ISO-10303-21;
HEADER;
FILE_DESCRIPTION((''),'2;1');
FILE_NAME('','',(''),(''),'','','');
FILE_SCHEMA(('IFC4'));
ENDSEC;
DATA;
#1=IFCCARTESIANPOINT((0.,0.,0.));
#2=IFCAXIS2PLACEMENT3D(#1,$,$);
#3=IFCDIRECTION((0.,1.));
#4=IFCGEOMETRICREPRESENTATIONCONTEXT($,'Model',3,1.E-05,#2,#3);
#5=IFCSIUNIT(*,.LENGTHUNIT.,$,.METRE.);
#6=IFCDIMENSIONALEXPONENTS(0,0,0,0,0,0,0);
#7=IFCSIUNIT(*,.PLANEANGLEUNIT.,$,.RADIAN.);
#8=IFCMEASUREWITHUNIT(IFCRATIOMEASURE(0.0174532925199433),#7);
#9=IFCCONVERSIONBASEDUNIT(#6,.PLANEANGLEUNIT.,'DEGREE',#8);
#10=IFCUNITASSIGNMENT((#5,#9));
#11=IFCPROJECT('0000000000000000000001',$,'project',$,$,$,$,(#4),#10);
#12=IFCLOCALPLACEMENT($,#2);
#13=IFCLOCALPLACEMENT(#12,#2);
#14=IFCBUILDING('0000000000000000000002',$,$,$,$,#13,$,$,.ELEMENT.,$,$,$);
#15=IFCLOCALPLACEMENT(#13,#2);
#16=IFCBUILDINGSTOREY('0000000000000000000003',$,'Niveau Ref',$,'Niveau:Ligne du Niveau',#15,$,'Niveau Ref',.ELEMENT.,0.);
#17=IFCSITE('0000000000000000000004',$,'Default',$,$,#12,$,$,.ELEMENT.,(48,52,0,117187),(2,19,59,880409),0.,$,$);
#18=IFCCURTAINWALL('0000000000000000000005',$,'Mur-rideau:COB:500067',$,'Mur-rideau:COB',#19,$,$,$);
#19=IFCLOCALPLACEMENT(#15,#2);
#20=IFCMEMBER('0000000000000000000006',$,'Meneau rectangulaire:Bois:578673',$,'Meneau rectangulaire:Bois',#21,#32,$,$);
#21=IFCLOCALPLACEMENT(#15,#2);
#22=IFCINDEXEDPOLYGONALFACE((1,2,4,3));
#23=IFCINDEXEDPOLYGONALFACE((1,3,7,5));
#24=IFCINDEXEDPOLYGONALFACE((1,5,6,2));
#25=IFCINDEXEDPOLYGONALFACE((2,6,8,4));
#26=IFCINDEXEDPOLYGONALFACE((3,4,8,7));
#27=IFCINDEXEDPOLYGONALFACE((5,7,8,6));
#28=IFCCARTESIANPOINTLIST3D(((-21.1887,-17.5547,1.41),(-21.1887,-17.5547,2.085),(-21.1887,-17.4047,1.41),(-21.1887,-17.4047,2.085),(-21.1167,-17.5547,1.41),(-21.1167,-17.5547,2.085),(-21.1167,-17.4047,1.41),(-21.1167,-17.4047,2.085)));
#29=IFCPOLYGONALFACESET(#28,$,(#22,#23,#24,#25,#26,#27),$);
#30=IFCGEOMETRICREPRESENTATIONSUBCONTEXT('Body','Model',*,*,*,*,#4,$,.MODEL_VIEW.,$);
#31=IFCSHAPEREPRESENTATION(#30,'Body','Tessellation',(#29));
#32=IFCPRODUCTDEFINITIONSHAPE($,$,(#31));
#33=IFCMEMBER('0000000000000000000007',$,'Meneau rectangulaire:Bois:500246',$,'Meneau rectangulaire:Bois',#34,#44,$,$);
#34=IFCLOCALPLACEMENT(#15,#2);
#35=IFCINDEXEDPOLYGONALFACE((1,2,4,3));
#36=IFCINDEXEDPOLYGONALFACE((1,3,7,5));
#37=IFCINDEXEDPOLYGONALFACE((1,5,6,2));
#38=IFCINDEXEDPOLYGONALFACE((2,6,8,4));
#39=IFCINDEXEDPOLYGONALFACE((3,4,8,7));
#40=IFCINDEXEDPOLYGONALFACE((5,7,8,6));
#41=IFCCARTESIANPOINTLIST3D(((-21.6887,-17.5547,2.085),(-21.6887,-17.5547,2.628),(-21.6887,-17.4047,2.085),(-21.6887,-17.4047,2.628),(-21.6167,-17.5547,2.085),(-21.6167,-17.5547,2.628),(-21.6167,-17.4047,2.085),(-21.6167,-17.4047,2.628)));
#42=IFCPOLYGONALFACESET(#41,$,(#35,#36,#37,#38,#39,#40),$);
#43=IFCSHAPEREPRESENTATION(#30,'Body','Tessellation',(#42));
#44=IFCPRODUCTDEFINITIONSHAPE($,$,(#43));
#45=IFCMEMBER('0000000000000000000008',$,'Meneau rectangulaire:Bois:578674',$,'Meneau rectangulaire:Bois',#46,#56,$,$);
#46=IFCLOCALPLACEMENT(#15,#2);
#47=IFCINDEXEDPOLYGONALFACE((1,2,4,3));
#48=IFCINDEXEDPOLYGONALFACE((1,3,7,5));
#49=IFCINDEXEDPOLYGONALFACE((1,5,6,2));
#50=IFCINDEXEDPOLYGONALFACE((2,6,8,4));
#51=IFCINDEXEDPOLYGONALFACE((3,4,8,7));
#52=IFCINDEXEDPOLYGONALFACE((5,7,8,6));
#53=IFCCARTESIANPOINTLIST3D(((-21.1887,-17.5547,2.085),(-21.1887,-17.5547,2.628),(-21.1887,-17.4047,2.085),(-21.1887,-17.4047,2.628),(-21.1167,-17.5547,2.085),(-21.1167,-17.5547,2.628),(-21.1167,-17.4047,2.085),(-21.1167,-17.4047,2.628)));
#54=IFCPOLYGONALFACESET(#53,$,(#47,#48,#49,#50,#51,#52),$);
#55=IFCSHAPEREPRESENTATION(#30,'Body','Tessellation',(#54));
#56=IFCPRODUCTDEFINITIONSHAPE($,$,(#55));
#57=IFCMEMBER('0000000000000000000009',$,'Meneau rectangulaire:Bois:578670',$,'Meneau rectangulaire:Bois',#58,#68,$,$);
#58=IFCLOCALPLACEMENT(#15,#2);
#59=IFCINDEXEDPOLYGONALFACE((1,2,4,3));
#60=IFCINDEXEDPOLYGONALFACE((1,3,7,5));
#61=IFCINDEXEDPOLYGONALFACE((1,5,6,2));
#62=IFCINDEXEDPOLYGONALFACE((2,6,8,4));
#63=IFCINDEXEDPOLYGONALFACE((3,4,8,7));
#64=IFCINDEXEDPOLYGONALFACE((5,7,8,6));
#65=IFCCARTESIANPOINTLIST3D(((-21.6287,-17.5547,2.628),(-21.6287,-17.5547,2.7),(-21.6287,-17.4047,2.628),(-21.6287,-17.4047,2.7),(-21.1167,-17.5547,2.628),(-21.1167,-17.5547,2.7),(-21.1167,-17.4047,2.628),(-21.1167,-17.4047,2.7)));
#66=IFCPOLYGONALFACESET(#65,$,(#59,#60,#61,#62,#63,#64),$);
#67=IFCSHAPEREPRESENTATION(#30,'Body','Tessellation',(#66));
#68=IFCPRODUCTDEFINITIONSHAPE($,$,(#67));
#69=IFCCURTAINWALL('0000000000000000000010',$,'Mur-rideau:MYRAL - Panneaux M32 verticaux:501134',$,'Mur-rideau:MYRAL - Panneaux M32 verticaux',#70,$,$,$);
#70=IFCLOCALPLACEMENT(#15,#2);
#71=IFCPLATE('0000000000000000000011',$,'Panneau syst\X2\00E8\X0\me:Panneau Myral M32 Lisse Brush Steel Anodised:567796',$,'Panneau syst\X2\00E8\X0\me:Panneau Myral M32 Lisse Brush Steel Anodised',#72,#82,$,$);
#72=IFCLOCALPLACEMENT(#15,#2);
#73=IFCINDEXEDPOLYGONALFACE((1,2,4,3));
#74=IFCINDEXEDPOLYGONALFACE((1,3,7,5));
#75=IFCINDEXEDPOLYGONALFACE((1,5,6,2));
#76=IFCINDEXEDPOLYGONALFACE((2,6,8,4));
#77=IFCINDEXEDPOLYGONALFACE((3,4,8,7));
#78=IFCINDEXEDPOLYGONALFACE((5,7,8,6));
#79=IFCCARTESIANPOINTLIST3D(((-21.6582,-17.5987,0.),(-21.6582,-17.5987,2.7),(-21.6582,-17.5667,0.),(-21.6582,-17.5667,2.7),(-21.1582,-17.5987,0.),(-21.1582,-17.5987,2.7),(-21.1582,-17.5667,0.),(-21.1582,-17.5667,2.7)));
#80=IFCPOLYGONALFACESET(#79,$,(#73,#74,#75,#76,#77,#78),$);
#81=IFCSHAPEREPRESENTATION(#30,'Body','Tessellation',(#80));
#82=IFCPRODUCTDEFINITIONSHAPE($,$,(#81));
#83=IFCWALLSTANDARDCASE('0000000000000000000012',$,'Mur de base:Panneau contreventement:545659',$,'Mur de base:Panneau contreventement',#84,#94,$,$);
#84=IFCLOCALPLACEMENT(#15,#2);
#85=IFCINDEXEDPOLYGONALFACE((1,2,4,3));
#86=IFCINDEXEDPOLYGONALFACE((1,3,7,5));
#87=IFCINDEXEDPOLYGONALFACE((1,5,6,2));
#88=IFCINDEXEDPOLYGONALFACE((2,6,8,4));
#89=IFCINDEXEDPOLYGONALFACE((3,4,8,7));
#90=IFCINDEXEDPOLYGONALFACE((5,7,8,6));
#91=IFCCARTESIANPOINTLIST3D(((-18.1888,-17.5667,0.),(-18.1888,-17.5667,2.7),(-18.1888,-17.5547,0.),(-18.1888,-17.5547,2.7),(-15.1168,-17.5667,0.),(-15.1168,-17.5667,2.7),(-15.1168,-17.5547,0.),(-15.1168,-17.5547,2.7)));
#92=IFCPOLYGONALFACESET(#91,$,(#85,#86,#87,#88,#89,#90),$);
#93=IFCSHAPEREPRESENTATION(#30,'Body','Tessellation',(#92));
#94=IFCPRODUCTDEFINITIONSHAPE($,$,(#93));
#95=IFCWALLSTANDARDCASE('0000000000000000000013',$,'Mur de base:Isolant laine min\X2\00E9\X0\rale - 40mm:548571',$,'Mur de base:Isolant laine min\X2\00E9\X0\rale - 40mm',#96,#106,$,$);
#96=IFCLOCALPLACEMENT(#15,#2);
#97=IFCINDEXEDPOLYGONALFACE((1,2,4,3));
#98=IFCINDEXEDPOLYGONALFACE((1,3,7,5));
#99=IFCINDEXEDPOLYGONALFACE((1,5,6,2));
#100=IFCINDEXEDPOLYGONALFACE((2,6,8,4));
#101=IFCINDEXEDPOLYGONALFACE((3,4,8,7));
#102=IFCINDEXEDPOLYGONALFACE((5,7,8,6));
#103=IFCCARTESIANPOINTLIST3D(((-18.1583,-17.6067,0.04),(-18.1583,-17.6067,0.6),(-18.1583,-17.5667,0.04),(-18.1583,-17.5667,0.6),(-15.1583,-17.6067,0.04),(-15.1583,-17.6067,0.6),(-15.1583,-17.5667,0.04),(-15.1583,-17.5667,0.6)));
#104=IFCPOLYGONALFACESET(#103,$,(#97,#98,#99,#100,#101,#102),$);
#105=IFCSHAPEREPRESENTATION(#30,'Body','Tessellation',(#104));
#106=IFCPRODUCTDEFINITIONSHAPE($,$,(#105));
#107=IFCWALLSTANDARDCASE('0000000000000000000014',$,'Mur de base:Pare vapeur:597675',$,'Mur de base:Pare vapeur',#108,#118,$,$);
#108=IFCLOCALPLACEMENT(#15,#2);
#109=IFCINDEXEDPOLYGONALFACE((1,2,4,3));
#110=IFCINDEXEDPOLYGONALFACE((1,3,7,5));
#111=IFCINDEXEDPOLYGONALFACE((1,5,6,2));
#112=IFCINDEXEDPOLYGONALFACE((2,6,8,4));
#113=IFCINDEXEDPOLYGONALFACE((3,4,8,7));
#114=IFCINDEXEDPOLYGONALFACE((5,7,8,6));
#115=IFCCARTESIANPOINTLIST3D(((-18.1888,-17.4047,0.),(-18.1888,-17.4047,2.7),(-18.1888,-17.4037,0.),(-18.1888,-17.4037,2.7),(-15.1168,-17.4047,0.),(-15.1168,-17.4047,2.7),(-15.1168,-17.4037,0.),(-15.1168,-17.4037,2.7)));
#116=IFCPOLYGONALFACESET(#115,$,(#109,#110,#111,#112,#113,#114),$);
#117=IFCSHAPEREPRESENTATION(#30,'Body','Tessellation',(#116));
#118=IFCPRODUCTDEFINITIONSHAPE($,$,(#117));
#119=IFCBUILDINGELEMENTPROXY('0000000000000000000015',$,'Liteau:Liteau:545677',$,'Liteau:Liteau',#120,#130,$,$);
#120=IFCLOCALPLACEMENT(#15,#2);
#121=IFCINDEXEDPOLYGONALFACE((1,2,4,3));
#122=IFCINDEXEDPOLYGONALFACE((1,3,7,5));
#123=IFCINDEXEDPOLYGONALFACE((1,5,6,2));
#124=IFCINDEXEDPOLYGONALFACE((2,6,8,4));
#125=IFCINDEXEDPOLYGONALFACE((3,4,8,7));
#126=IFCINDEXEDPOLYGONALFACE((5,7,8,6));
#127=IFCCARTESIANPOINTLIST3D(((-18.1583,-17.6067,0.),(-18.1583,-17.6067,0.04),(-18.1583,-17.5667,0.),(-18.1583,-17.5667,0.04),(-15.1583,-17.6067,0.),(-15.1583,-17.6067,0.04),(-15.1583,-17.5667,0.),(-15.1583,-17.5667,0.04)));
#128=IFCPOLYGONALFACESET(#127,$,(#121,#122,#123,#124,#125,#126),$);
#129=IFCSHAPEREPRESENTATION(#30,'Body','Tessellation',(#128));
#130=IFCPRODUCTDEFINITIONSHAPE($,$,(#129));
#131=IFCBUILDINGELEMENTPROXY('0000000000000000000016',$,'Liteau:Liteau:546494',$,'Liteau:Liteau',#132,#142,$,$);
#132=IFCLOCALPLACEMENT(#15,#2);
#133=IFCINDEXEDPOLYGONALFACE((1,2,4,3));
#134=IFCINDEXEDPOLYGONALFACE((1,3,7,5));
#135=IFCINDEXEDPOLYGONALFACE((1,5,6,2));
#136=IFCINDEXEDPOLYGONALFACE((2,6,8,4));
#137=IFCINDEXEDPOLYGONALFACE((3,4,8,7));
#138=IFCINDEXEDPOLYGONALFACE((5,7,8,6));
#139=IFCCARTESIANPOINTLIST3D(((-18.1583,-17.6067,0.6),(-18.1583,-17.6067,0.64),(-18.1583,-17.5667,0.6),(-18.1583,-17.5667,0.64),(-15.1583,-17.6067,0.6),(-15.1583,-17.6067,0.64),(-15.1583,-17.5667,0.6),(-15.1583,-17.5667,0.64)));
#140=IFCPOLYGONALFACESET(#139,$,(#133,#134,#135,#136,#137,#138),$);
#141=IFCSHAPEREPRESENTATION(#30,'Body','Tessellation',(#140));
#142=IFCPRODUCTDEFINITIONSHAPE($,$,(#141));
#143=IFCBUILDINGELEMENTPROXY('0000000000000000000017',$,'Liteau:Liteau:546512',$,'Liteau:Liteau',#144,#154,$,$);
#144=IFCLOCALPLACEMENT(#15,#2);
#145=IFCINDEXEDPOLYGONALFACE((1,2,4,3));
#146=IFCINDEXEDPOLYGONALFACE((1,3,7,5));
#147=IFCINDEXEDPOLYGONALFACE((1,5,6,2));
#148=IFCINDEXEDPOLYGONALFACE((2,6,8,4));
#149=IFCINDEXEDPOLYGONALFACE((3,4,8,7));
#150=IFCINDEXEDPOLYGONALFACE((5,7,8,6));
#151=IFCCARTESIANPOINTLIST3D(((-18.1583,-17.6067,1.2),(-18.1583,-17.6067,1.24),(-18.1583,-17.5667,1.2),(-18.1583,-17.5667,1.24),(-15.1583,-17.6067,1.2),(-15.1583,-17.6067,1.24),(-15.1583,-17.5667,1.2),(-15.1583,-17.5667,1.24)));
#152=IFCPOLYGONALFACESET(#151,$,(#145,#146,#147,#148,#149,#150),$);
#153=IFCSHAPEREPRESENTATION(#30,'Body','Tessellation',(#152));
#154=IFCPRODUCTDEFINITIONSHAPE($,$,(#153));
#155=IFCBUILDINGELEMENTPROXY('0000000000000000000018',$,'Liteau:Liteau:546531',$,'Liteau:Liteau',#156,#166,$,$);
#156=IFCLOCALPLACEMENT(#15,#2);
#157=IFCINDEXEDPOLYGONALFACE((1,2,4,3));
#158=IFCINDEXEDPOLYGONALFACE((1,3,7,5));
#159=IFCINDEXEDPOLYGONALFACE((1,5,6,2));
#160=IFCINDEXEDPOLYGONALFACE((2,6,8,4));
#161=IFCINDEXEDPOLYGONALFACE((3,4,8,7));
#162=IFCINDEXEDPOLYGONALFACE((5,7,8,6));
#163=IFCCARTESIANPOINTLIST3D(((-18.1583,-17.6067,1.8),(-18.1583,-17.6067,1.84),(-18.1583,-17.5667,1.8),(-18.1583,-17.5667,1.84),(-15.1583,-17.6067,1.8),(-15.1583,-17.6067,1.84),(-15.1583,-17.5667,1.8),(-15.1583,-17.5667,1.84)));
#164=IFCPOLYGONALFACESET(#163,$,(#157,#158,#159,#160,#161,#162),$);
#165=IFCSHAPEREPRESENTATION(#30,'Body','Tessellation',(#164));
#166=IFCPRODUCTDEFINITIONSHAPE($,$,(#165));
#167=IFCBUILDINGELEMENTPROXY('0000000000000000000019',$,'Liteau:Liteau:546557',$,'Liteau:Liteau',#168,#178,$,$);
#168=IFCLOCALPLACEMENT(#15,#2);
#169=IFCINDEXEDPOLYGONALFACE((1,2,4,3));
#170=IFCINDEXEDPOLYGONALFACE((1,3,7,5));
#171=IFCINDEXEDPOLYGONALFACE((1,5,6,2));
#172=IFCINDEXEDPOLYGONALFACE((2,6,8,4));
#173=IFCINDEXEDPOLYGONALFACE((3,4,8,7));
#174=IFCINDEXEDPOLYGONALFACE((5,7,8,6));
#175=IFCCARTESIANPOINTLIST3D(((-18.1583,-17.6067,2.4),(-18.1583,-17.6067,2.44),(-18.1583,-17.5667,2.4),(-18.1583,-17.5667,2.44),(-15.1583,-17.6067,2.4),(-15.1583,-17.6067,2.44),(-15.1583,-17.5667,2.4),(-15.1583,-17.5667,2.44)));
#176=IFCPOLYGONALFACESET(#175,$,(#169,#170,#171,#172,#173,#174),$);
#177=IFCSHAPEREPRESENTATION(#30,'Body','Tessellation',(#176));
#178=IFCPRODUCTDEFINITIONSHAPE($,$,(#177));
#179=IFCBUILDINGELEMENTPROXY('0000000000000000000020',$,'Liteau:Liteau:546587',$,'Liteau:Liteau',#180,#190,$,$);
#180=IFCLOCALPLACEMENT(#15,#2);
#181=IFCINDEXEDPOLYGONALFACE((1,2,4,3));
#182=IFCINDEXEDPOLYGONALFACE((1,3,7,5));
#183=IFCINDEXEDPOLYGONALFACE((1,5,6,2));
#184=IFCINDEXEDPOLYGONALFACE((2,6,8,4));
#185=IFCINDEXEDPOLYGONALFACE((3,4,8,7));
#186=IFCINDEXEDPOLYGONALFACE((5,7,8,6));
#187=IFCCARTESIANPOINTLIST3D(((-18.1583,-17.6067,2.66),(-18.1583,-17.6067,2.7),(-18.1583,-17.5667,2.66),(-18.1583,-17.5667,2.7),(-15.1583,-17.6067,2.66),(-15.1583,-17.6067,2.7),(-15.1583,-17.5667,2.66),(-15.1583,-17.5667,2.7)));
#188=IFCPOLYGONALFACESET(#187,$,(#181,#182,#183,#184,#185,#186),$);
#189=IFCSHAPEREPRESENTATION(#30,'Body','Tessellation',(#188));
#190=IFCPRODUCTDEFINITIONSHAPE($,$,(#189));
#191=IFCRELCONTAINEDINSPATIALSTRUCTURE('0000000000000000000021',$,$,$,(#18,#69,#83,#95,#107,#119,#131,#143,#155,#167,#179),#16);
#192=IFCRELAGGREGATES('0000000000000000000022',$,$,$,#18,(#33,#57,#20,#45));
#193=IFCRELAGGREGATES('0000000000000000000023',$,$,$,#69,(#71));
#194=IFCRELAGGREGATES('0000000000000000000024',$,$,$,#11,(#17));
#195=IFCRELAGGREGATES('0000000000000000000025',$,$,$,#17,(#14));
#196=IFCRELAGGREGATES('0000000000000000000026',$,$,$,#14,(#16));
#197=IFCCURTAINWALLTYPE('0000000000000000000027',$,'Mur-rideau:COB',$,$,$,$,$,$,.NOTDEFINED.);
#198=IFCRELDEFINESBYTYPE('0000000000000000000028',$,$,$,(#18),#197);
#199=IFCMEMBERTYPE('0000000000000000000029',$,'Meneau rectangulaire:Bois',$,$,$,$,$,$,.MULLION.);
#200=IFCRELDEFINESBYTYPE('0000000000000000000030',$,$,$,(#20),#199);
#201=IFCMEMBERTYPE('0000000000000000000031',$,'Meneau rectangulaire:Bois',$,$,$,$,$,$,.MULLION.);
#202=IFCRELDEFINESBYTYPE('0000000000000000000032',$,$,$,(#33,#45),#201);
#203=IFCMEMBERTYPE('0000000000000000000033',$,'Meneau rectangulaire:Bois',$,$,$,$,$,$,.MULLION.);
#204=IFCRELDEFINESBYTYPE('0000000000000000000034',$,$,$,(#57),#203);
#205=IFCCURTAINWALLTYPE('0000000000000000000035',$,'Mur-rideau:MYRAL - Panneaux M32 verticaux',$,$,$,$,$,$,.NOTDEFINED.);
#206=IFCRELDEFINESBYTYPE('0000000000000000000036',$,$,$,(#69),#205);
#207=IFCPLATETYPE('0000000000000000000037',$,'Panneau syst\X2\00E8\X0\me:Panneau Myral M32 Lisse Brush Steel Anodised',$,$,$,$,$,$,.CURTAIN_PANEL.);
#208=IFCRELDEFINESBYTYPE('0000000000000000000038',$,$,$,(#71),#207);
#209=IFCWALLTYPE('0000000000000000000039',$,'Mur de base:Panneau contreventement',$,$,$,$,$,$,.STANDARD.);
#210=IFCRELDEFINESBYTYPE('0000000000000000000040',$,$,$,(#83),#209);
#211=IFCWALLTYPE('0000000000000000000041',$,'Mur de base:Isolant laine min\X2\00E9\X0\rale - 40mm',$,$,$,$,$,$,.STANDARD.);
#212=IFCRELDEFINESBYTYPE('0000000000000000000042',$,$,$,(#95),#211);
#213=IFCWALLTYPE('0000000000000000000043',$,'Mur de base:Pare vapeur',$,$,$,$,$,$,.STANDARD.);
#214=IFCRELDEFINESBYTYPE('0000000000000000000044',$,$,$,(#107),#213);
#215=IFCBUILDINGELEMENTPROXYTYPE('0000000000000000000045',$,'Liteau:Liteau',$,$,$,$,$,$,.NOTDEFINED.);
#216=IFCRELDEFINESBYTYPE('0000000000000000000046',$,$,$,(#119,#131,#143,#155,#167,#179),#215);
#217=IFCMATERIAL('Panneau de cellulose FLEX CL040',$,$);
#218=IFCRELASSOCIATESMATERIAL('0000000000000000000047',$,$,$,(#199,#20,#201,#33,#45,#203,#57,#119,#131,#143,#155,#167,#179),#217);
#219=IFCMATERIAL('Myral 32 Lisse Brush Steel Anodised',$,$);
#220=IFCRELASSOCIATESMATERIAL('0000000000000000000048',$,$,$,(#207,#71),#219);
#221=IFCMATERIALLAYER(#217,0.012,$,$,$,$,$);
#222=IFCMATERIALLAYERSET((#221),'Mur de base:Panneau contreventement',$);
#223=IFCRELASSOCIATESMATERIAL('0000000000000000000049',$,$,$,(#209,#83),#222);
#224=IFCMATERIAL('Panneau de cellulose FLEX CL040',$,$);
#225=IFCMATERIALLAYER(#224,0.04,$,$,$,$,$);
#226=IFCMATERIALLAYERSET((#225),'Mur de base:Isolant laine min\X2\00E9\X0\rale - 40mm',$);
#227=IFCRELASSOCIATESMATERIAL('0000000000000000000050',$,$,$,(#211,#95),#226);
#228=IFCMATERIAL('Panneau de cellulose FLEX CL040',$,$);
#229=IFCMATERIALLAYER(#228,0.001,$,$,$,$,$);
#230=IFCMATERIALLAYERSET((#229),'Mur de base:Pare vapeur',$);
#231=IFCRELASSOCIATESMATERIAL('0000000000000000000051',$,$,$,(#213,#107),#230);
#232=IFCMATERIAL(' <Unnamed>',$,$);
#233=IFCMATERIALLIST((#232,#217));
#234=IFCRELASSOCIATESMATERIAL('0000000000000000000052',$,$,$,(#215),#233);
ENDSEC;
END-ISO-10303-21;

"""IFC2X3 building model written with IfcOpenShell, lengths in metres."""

from ifc_helpers import new_model, entity, si_unit, converted_unit, direction, frame, frame_2d, origin, origin_2d_with_axis, place, context, subcontext, project, spatial, rectangle, extrude, source, transform, mapped, material, material_list, layer, layer_set, layer_usage, type_object, type_shapes, element, aggregate, save


model = new_model("IFC2X3")

# Units and contexts
model_context = context("Model", 3, precision=1e-05, world=origin(), true_north=direction((0.0, 1.0)))
body_context = subcontext(model_context, "Body", "Model", "MODEL_VIEW")
ifc_project = project(units=[si_unit("LENGTHUNIT", "METRE"), converted_unit("PLANEANGLEUNIT", "DEGREE", entity("IfcRatioMeasure", 0.0174532925199433), si_unit("PLANEANGLEUNIT", "RADIAN"), dimensions=[0, 0, 0, 0, 0, 0, 0])], contexts=[model_context])

# Site, building, storey
site_placement = place(None, origin())
site = spatial("IfcSite", under=ifc_project, at=site_placement, Name="Default", CompositionType="ELEMENT", RefLatitude=(48, 52, 0, 117187), RefLongitude=(2, 19, 59, 880409), RefElevation=0.0)
building_placement = place(site_placement, origin())
building = spatial("IfcBuilding", under=site, at=building_placement, CompositionType="ELEMENT")
storey_placement = place(building_placement, origin())
storey = spatial("IfcBuildingStorey", under=building, at=storey_placement, Name="Niveau Ref", ObjectType="Niveau:Ligne du Niveau", LongName="Niveau Ref", CompositionType="ELEMENT", Elevation=0.0)

# Curtain wall, members
curtain_wall_type_1 = type_object("IfcCurtainWallType", Name="Mur-rideau:COB", PredefinedType="NOTDEFINED")
ifc_material_1 = material(Name="Panneau de cellulose FLEX CL040")
curtain_wall_1_placement = place(storey_placement, origin())
curtain_wall_1 = element("IfcCurtainWall", 1, at=curtain_wall_1_placement, inside=storey, type_object=curtain_wall_type_1, Name="Mur-rideau:COB:500067", ObjectType="Mur-rideau:COB")
member_type_1 = type_object("IfcMemberType", Name="Meneau rectangulaire:Bois", PredefinedType="MULLION", material=ifc_material_1)
shared_shape_1 = source(origin(), body_context, "Body", "SweptSolid", [
    extrude(rectangle(XDim=0.15, YDim=0.072, at=origin_2d_with_axis()), frame((-0.024, 0.0, -0.675), z_axis=(0.0, 0.0, 1.0), x_axis=(0.0, -1.0, 0.0)), (0.0, 0.0, 1.0), 0.675),
])
type_shapes(member_type_1, [shared_shape_1])
member_1_placement = place(storey_placement, frame((-21.1287, -17.4797, 1.41), z_axis=(0.0, 0.0, -1.0), x_axis=(1.0, 0.0, 0.0)))
member_1 = element("IfcMember", 2, at=member_1_placement, type_object=member_type_1, material=ifc_material_1, Name="Meneau rectangulaire:Bois:578673", ObjectType="Meneau rectangulaire:Bois", context=body_context, shape_type="MappedRepresentation", body=[
    mapped(shared_shape_1, transform((0.0, 0.0, 0.0), scale=1.0)),
])
member_type_2 = type_object("IfcMemberType", Name="Meneau rectangulaire:Bois", PredefinedType="MULLION", material=ifc_material_1)
shared_shape_2 = source(origin(), body_context, "Body", "SweptSolid", [
    extrude(rectangle(XDim=0.15, YDim=0.072, at=origin_2d_with_axis()), frame((-0.024, 0.0, -0.543), z_axis=(0.0, 0.0, 1.0), x_axis=(0.0, -1.0, 0.0)), (0.0, 0.0, 1.0), 0.543),
])
type_shapes(member_type_2, [shared_shape_2])
member_2_placement = place(storey_placement, frame((-21.6287, -17.4797, 2.085), z_axis=(0.0, 0.0, -1.0), x_axis=(1.0, 0.0, 0.0)))
member_2 = element("IfcMember", 3, at=member_2_placement, type_object=member_type_2, material=ifc_material_1, Name="Meneau rectangulaire:Bois:500246", ObjectType="Meneau rectangulaire:Bois", context=body_context, shape_type="MappedRepresentation", body=[
    mapped(shared_shape_2, transform((0.0, 0.0, 0.0), scale=1.0)),
])
member_3_placement = place(storey_placement, frame((-21.1287, -17.4797, 2.085), z_axis=(0.0, 0.0, -1.0), x_axis=(1.0, 0.0, 0.0)))
member_3 = element("IfcMember", 4, at=member_3_placement, type_object=member_type_2, material=ifc_material_1, Name="Meneau rectangulaire:Bois:578674", ObjectType="Meneau rectangulaire:Bois", context=body_context, shape_type="MappedRepresentation", body=[
    mapped(shared_shape_2, transform((0.0, 0.0, 0.0), scale=1.0)),
])
member_type_3 = type_object("IfcMemberType", Name="Meneau rectangulaire:Bois", PredefinedType="MULLION", material=ifc_material_1)
shared_shape_3 = source(origin(), body_context, "Body", "SweptSolid", [
    extrude(rectangle(XDim=0.15, YDim=0.072, at=origin_2d_with_axis()), frame((-0.036, 0.0, -0.512), z_axis=(0.0, 0.0, 1.0), x_axis=(0.0, -1.0, 0.0)), (0.0, 0.0, 1.0), 0.512),
])
type_shapes(member_type_3, [shared_shape_3])
member_4_placement = place(storey_placement, frame((-21.1167, -17.4797, 2.7), z_axis=(1.0, 0.0, 0.0), x_axis=(0.0, 0.0, 1.0)))
member_4 = element("IfcMember", 5, at=member_4_placement, type_object=member_type_3, material=ifc_material_1, Name="Meneau rectangulaire:Bois:578670", ObjectType="Meneau rectangulaire:Bois", context=body_context, shape_type="MappedRepresentation", body=[
    mapped(shared_shape_3, transform((0.0, 0.0, 0.0), scale=1.0)),
])
aggregate(curtain_wall_1, [member_2, member_4, member_1, member_3])

# Curtain wall, plate
curtain_wall_type_2 = type_object("IfcCurtainWallType", Name="Mur-rideau:MYRAL - Panneaux M32 verticaux", PredefinedType="NOTDEFINED")
curtain_wall_2_placement = place(storey_placement, origin())
curtain_wall_2 = element("IfcCurtainWall", 6, at=curtain_wall_2_placement, inside=storey, type_object=curtain_wall_type_2, Name="Mur-rideau:MYRAL - Panneaux M32 verticaux:501134", ObjectType="Mur-rideau:MYRAL - Panneaux M32 verticaux")
ifc_material_2 = material(Name="Myral 32 Lisse Brush Steel Anodised")
plate_type = type_object("IfcPlateType", Name="Panneau système:Panneau Myral M32 Lisse Brush Steel Anodised", PredefinedType="CURTAIN_PANEL", material=ifc_material_2)
shared_shape_4 = source(origin(), body_context, "Body", "SweptSolid", [
    extrude(rectangle(XDim=0.032, YDim=0.5, at=origin_2d_with_axis()), frame((0.0, -0.016, 0.0), z_axis=(0.0, 0.0, 1.0), x_axis=(0.0, 1.0, 0.0)), (0.0, 0.0, 1.0), 2.7),
])
type_shapes(plate_type, [shared_shape_4])
plate_placement = place(curtain_wall_2_placement, frame((-21.4082, -17.5667, 0.0)))
plate = element("IfcPlate", 7, at=plate_placement, type_object=plate_type, material=ifc_material_2, Name="Panneau système:Panneau Myral M32 Lisse Brush Steel Anodised:567796", ObjectType="Panneau système:Panneau Myral M32 Lisse Brush Steel Anodised", context=body_context, shape_type="MappedRepresentation", body=[
    mapped(shared_shape_4, transform((0.0, 0.0, 0.0), scale=1.0)),
])
aggregate(curtain_wall_2, [plate])

# Walls
ifc_layer_1 = layer(ifc_material_1, 0.012)
ifc_layer_set_1 = layer_set([ifc_layer_1], Name="Mur de base:Panneau contreventement")
ifc_layer_usage_1 = layer_usage(ifc_layer_set_1, "AXIS2", "NEGATIVE", 0.006)
wall_type_1 = type_object("IfcWallType", Name="Mur de base:Panneau contreventement", PredefinedType="STANDARD", material=ifc_layer_set_1)
wall_1_placement = place(storey_placement, frame((-18.1888, -17.5607, 0.0)))
element("IfcWallStandardCase", 8, at=wall_1_placement, inside=storey, type_object=wall_type_1, material=ifc_layer_usage_1, Name="Mur de base:Panneau contreventement:545659", ObjectType="Mur de base:Panneau contreventement", context=body_context, shape_type="SweptSolid", body=[
    extrude(rectangle(XDim=3.072, YDim=0.012, at=frame_2d((1.536, 0.0), x_axis=(-1.0, 0.0))), origin(), (0.0, 0.0, 1.0), 2.7),
])
ifc_material_3 = material(Name="Panneau de cellulose FLEX CL040")
ifc_layer_2 = layer(ifc_material_3, 0.04)
ifc_layer_set_2 = layer_set([ifc_layer_2], Name="Mur de base:Isolant laine minérale - 40mm")
ifc_layer_usage_2 = layer_usage(ifc_layer_set_2, "AXIS2", "NEGATIVE", 0.02)
wall_type_2 = type_object("IfcWallType", Name="Mur de base:Isolant laine minérale - 40mm", PredefinedType="STANDARD", material=ifc_layer_set_2)
wall_2_placement = place(storey_placement, frame((-18.1583, -17.5867, 0.04)))
element("IfcWallStandardCase", 9, at=wall_2_placement, inside=storey, type_object=wall_type_2, material=ifc_layer_usage_2, Name="Mur de base:Isolant laine minérale - 40mm:548571", ObjectType="Mur de base:Isolant laine minérale - 40mm", context=body_context, shape_type="SweptSolid", body=[
    extrude(rectangle(XDim=3.0, YDim=0.04, at=frame_2d((1.5, 0.0), x_axis=(-1.0, 0.0))), origin(), (0.0, 0.0, 1.0), 0.56),
])
ifc_material_4 = material(Name="Panneau de cellulose FLEX CL040")
ifc_layer_3 = layer(ifc_material_4, 0.001)
ifc_layer_set_3 = layer_set([ifc_layer_3], Name="Mur de base:Pare vapeur")
ifc_layer_usage_3 = layer_usage(ifc_layer_set_3, "AXIS2", "NEGATIVE", 0.0005)
wall_type_3 = type_object("IfcWallType", Name="Mur de base:Pare vapeur", PredefinedType="STANDARD", material=ifc_layer_set_3)
wall_3_placement = place(storey_placement, frame((-18.1888, -17.4042, 0.0)))
element("IfcWallStandardCase", 10, at=wall_3_placement, inside=storey, type_object=wall_type_3, material=ifc_layer_usage_3, Name="Mur de base:Pare vapeur:597675", ObjectType="Mur de base:Pare vapeur", context=body_context, shape_type="SweptSolid", body=[
    extrude(rectangle(XDim=3.072, YDim=0.001, at=frame_2d((1.536, 0.0), x_axis=(-1.0, 0.0))), origin(), (0.0, 0.0, 1.0), 2.7),
])

# Building element proxies
ifc_material_5 = material(Name=" <Unnamed>")
ifc_material_list = material_list([ifc_material_5, ifc_material_1])
building_element_proxy_type = type_object("IfcBuildingElementProxyType", Name="Liteau:Liteau", PredefinedType="NOTDEFINED", material=ifc_material_list)
shared_shape_5 = source(origin(), body_context, "Body", "SweptSolid", [
    extrude(rectangle(XDim=3.0, YDim=0.04, at=origin_2d_with_axis()), frame((1.5, -0.02, 0.0), z_axis=(0.0, 0.0, 1.0), x_axis=(-1.0, 0.0, 0.0)), (0.0, 0.0, 1.0), 0.04),
])
type_shapes(building_element_proxy_type, [shared_shape_5])
for number, where, name in (
    (11, (-18.1583, -17.5667, 0.0), "Liteau:Liteau:545677"),
    (12, (-18.1583, -17.5667, 0.6), "Liteau:Liteau:546494"),
    (13, (-18.1583, -17.5667, 1.2), "Liteau:Liteau:546512"),
    (14, (-18.1583, -17.5667, 1.8), "Liteau:Liteau:546531"),
    (15, (-18.1583, -17.5667, 2.4), "Liteau:Liteau:546557"),
    (16, (-18.1583, -17.5667, 2.66), "Liteau:Liteau:546587"),
):
    element("IfcBuildingElementProxy", number, at=place(storey_placement, frame(where)), inside=storey, type_object=building_element_proxy_type, material=ifc_material_1, Name=name, ObjectType="Liteau:Liteau", context=body_context, shape_type="MappedRepresentation", body=[
        mapped(shared_shape_5, transform((0.0, 0.0, 0.0), scale=1.0)),
    ])

save(model, "model.ifc")
